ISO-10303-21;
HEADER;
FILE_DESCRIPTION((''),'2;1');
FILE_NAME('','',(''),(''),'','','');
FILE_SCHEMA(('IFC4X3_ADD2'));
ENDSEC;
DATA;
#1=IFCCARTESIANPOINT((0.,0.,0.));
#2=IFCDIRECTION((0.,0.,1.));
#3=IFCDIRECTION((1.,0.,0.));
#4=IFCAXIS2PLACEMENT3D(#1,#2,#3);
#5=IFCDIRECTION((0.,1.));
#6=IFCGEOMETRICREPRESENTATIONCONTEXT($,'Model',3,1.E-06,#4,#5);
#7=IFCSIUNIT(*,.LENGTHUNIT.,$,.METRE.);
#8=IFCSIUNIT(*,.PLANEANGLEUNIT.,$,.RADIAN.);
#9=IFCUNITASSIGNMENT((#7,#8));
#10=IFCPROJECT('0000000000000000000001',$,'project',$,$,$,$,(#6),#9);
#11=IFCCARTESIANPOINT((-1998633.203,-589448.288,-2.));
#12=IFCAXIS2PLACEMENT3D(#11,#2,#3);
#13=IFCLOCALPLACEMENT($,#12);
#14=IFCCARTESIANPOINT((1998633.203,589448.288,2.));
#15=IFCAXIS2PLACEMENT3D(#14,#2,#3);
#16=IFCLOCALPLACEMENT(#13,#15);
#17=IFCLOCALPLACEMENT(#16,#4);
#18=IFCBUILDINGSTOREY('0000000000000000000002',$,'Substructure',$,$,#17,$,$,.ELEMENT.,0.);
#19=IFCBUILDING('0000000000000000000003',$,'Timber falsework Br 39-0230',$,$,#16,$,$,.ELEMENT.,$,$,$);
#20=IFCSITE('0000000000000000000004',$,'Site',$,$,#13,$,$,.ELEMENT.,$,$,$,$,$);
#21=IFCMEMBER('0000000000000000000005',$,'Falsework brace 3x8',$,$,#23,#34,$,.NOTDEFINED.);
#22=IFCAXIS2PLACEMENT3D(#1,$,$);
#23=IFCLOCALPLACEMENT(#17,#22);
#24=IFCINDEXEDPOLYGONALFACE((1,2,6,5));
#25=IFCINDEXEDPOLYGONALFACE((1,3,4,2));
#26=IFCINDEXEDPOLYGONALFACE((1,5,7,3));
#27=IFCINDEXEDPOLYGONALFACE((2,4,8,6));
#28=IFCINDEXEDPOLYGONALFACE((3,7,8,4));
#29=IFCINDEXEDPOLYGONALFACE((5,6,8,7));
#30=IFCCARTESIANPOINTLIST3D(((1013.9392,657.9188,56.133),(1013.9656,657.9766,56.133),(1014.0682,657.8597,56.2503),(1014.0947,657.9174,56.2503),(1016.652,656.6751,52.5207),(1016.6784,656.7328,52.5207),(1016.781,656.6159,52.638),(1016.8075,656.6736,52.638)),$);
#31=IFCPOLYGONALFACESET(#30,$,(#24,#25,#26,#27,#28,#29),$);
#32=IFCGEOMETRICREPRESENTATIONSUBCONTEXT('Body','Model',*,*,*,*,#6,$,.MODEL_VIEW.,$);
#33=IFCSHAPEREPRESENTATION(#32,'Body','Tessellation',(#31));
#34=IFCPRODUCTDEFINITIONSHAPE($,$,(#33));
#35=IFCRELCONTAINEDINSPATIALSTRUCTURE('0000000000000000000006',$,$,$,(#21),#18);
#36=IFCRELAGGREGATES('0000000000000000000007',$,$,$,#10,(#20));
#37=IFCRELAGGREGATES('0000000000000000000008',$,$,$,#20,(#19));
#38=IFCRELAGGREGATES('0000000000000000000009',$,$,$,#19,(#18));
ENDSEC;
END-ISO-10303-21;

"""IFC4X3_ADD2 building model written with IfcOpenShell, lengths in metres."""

from ifc_helpers import new_model, si_unit, direction, frame, origin, origin_with_axes, origin_2d, place, context, subcontext, project, spatial, rectangle, extrude, element, save


model = new_model("IFC4X3_ADD2")

# Units and contexts
model_context = context("Model", 3, precision=1e-06, world=origin_with_axes(), true_north=direction((0.0, 1.0)))
body_context = subcontext(model_context, "Body", "Model", "MODEL_VIEW")
ifc_project = project(units=[si_unit("LENGTHUNIT", "METRE"), si_unit("PLANEANGLEUNIT", "RADIAN")], contexts=[model_context])

# Site, building, storey
site_placement = place(None, frame((-1998633.203, -589448.288, -2.0), z_axis=(0.0, 0.0, 1.0), x_axis=(1.0, 0.0, 0.0)))
site = spatial("IfcSite", under=ifc_project, at=site_placement, Name="Site", CompositionType="ELEMENT")
building_placement = place(site_placement, frame((1998633.203, 589448.288, 2.0), z_axis=(0.0, 0.0, 1.0), x_axis=(1.0, 0.0, 0.0)))
building = spatial("IfcBuilding", under=site, at=building_placement, Name="Timber falsework Br 39-0230", CompositionType="ELEMENT")
storey_placement = place(building_placement, origin_with_axes())
storey = spatial("IfcBuildingStorey", under=building, at=storey_placement, Name="Substructure", CompositionType="ELEMENT", Elevation=0.0)

# Member
member_1_placement = place(storey_placement, frame((1014.0169, 657.9181, 56.1917), z_axis=(0.578959, -0.265441, -0.77094), x_axis=(0.416765, 0.909014, 0.0)))
element("IfcMember", 1, at=member_1_placement, inside=storey, Name="Falsework brace 3x8", PredefinedType="NOTDEFINED", context=body_context, shape_type="SweptSolid", body=[
    extrude(rectangle(XDim=0.0635, YDim=0.1841, at=origin_2d()), origin(), (0.0, 0.0, 1.0), 4.6857),
])

save(model, "model.ifc")
